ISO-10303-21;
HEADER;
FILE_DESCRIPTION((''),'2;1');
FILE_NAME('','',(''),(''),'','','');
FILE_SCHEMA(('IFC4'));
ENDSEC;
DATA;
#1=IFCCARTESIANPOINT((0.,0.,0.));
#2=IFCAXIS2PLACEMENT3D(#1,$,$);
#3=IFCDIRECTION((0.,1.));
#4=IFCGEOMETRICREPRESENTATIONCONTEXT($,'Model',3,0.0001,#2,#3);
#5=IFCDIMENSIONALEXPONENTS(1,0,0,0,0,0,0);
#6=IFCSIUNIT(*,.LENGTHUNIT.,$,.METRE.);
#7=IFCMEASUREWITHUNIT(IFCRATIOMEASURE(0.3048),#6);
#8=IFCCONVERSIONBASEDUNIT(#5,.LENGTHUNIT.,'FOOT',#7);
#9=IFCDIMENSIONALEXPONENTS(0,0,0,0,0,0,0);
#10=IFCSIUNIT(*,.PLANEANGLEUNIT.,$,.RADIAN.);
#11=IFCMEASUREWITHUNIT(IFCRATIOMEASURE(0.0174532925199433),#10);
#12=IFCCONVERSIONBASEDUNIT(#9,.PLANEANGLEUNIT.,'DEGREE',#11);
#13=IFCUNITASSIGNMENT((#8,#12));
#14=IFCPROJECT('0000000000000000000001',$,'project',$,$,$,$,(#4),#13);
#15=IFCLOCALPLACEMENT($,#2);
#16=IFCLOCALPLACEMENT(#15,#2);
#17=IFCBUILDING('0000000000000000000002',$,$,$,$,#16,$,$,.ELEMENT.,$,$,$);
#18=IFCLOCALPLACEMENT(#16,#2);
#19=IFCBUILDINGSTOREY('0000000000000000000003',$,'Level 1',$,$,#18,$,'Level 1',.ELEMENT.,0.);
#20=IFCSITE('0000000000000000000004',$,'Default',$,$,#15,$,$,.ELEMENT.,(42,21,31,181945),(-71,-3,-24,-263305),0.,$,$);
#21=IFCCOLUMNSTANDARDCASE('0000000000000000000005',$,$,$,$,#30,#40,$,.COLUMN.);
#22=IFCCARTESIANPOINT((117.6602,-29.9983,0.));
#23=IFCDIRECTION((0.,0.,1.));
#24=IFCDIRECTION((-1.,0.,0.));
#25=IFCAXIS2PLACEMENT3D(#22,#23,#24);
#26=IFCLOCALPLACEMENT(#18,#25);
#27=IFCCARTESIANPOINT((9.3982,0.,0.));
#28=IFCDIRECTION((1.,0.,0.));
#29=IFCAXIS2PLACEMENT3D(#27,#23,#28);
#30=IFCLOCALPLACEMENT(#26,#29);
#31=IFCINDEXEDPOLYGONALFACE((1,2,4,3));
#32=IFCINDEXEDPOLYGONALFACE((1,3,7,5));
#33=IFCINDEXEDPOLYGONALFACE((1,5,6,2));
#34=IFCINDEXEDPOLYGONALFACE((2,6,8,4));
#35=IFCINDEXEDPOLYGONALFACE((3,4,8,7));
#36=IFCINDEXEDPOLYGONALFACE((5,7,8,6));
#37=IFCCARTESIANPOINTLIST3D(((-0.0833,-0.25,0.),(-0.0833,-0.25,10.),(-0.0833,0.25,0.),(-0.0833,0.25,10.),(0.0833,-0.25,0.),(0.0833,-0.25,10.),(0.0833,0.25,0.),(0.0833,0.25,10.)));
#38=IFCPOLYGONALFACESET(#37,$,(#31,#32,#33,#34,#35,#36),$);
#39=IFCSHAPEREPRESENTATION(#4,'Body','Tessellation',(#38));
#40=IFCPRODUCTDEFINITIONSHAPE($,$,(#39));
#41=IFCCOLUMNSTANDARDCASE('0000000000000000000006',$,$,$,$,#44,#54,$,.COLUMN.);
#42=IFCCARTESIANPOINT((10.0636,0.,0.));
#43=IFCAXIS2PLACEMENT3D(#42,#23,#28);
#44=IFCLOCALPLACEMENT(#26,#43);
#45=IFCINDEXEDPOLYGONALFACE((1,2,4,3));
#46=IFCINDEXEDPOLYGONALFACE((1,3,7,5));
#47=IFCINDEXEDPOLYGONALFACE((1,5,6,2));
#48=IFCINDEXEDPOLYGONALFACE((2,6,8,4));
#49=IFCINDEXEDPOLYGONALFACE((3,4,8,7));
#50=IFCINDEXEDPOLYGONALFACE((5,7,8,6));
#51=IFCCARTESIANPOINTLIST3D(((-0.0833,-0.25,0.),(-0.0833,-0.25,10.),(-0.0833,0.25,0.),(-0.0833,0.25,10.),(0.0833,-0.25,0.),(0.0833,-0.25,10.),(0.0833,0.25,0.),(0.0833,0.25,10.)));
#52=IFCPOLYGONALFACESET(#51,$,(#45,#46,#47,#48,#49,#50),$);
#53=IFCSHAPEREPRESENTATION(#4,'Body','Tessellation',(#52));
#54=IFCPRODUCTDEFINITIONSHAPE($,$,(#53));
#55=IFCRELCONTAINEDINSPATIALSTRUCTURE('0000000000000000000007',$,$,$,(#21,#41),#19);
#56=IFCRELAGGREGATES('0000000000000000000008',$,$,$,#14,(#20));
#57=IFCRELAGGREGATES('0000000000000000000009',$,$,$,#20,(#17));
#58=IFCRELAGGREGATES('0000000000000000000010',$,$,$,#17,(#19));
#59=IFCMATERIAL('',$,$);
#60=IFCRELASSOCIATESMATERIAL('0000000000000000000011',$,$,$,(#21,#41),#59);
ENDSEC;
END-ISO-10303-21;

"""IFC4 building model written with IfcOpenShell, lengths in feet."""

from ifc_helpers import new_model, entity, si_unit, converted_unit, direction, frame, origin, place, context, project, spatial, rectangle, extrude, material, element, save


model = new_model("IFC4")

# Units and contexts
model_context = context("Model", 3, precision=0.0001, world=origin(), true_north=direction((0.0, 1.0)))
ifc_project = project(units=[converted_unit("LENGTHUNIT", "FOOT", entity("IfcRatioMeasure", 0.3048), si_unit("LENGTHUNIT", "METRE"), dimensions=[1, 0, 0, 0, 0, 0, 0]), converted_unit("PLANEANGLEUNIT", "DEGREE", entity("IfcRatioMeasure", 0.0174532925199433), si_unit("PLANEANGLEUNIT", "RADIAN"), dimensions=[0, 0, 0, 0, 0, 0, 0])], contexts=[model_context])

# Site, building, storey
site_placement = place(None, origin())
site = spatial("IfcSite", under=ifc_project, at=site_placement, Name="Default", CompositionType="ELEMENT", RefLatitude=(42, 21, 31, 181945), RefLongitude=(-71, -3, -24, -263305), RefElevation=0.0)
building_placement = place(site_placement, origin())
building = spatial("IfcBuilding", under=site, at=building_placement, CompositionType="ELEMENT")
storey_placement = place(building_placement, origin())
storey = spatial("IfcBuildingStorey", under=building, at=storey_placement, Name="Level 1", LongName="Level 1", CompositionType="ELEMENT", Elevation=0.0)

# Columns
ifc_material_1 = material(Name="")
wall_placement = place(storey_placement, frame((117.6602, -29.9983, 0.0), z_axis=(0.0, 0.0, 1.0), x_axis=(-1.0, 0.0, 0.0)))
for number, where, z_axis, x_axis in (
    (1, (9.3982, 0.0, 0.0), (0.0, 0.0, 1.0), (1.0, 0.0, 0.0)),
    (2, (10.0636, 0.0, 0.0), (0.0, 0.0, 1.0), (1.0, 0.0, 0.0)),
):
    element("IfcColumnStandardCase", number, at=place(wall_placement, frame(where, z_axis=z_axis, x_axis=x_axis)), inside=storey, material=ifc_material_1, PredefinedType="COLUMN", context=model_context, shape_type="SweptSolid", body=[
        extrude(rectangle(XDim=0.1667, YDim=0.5), origin(), (0.0, 0.0, 1.0), 10.0),
    ])

save(model, "model.ifc")
